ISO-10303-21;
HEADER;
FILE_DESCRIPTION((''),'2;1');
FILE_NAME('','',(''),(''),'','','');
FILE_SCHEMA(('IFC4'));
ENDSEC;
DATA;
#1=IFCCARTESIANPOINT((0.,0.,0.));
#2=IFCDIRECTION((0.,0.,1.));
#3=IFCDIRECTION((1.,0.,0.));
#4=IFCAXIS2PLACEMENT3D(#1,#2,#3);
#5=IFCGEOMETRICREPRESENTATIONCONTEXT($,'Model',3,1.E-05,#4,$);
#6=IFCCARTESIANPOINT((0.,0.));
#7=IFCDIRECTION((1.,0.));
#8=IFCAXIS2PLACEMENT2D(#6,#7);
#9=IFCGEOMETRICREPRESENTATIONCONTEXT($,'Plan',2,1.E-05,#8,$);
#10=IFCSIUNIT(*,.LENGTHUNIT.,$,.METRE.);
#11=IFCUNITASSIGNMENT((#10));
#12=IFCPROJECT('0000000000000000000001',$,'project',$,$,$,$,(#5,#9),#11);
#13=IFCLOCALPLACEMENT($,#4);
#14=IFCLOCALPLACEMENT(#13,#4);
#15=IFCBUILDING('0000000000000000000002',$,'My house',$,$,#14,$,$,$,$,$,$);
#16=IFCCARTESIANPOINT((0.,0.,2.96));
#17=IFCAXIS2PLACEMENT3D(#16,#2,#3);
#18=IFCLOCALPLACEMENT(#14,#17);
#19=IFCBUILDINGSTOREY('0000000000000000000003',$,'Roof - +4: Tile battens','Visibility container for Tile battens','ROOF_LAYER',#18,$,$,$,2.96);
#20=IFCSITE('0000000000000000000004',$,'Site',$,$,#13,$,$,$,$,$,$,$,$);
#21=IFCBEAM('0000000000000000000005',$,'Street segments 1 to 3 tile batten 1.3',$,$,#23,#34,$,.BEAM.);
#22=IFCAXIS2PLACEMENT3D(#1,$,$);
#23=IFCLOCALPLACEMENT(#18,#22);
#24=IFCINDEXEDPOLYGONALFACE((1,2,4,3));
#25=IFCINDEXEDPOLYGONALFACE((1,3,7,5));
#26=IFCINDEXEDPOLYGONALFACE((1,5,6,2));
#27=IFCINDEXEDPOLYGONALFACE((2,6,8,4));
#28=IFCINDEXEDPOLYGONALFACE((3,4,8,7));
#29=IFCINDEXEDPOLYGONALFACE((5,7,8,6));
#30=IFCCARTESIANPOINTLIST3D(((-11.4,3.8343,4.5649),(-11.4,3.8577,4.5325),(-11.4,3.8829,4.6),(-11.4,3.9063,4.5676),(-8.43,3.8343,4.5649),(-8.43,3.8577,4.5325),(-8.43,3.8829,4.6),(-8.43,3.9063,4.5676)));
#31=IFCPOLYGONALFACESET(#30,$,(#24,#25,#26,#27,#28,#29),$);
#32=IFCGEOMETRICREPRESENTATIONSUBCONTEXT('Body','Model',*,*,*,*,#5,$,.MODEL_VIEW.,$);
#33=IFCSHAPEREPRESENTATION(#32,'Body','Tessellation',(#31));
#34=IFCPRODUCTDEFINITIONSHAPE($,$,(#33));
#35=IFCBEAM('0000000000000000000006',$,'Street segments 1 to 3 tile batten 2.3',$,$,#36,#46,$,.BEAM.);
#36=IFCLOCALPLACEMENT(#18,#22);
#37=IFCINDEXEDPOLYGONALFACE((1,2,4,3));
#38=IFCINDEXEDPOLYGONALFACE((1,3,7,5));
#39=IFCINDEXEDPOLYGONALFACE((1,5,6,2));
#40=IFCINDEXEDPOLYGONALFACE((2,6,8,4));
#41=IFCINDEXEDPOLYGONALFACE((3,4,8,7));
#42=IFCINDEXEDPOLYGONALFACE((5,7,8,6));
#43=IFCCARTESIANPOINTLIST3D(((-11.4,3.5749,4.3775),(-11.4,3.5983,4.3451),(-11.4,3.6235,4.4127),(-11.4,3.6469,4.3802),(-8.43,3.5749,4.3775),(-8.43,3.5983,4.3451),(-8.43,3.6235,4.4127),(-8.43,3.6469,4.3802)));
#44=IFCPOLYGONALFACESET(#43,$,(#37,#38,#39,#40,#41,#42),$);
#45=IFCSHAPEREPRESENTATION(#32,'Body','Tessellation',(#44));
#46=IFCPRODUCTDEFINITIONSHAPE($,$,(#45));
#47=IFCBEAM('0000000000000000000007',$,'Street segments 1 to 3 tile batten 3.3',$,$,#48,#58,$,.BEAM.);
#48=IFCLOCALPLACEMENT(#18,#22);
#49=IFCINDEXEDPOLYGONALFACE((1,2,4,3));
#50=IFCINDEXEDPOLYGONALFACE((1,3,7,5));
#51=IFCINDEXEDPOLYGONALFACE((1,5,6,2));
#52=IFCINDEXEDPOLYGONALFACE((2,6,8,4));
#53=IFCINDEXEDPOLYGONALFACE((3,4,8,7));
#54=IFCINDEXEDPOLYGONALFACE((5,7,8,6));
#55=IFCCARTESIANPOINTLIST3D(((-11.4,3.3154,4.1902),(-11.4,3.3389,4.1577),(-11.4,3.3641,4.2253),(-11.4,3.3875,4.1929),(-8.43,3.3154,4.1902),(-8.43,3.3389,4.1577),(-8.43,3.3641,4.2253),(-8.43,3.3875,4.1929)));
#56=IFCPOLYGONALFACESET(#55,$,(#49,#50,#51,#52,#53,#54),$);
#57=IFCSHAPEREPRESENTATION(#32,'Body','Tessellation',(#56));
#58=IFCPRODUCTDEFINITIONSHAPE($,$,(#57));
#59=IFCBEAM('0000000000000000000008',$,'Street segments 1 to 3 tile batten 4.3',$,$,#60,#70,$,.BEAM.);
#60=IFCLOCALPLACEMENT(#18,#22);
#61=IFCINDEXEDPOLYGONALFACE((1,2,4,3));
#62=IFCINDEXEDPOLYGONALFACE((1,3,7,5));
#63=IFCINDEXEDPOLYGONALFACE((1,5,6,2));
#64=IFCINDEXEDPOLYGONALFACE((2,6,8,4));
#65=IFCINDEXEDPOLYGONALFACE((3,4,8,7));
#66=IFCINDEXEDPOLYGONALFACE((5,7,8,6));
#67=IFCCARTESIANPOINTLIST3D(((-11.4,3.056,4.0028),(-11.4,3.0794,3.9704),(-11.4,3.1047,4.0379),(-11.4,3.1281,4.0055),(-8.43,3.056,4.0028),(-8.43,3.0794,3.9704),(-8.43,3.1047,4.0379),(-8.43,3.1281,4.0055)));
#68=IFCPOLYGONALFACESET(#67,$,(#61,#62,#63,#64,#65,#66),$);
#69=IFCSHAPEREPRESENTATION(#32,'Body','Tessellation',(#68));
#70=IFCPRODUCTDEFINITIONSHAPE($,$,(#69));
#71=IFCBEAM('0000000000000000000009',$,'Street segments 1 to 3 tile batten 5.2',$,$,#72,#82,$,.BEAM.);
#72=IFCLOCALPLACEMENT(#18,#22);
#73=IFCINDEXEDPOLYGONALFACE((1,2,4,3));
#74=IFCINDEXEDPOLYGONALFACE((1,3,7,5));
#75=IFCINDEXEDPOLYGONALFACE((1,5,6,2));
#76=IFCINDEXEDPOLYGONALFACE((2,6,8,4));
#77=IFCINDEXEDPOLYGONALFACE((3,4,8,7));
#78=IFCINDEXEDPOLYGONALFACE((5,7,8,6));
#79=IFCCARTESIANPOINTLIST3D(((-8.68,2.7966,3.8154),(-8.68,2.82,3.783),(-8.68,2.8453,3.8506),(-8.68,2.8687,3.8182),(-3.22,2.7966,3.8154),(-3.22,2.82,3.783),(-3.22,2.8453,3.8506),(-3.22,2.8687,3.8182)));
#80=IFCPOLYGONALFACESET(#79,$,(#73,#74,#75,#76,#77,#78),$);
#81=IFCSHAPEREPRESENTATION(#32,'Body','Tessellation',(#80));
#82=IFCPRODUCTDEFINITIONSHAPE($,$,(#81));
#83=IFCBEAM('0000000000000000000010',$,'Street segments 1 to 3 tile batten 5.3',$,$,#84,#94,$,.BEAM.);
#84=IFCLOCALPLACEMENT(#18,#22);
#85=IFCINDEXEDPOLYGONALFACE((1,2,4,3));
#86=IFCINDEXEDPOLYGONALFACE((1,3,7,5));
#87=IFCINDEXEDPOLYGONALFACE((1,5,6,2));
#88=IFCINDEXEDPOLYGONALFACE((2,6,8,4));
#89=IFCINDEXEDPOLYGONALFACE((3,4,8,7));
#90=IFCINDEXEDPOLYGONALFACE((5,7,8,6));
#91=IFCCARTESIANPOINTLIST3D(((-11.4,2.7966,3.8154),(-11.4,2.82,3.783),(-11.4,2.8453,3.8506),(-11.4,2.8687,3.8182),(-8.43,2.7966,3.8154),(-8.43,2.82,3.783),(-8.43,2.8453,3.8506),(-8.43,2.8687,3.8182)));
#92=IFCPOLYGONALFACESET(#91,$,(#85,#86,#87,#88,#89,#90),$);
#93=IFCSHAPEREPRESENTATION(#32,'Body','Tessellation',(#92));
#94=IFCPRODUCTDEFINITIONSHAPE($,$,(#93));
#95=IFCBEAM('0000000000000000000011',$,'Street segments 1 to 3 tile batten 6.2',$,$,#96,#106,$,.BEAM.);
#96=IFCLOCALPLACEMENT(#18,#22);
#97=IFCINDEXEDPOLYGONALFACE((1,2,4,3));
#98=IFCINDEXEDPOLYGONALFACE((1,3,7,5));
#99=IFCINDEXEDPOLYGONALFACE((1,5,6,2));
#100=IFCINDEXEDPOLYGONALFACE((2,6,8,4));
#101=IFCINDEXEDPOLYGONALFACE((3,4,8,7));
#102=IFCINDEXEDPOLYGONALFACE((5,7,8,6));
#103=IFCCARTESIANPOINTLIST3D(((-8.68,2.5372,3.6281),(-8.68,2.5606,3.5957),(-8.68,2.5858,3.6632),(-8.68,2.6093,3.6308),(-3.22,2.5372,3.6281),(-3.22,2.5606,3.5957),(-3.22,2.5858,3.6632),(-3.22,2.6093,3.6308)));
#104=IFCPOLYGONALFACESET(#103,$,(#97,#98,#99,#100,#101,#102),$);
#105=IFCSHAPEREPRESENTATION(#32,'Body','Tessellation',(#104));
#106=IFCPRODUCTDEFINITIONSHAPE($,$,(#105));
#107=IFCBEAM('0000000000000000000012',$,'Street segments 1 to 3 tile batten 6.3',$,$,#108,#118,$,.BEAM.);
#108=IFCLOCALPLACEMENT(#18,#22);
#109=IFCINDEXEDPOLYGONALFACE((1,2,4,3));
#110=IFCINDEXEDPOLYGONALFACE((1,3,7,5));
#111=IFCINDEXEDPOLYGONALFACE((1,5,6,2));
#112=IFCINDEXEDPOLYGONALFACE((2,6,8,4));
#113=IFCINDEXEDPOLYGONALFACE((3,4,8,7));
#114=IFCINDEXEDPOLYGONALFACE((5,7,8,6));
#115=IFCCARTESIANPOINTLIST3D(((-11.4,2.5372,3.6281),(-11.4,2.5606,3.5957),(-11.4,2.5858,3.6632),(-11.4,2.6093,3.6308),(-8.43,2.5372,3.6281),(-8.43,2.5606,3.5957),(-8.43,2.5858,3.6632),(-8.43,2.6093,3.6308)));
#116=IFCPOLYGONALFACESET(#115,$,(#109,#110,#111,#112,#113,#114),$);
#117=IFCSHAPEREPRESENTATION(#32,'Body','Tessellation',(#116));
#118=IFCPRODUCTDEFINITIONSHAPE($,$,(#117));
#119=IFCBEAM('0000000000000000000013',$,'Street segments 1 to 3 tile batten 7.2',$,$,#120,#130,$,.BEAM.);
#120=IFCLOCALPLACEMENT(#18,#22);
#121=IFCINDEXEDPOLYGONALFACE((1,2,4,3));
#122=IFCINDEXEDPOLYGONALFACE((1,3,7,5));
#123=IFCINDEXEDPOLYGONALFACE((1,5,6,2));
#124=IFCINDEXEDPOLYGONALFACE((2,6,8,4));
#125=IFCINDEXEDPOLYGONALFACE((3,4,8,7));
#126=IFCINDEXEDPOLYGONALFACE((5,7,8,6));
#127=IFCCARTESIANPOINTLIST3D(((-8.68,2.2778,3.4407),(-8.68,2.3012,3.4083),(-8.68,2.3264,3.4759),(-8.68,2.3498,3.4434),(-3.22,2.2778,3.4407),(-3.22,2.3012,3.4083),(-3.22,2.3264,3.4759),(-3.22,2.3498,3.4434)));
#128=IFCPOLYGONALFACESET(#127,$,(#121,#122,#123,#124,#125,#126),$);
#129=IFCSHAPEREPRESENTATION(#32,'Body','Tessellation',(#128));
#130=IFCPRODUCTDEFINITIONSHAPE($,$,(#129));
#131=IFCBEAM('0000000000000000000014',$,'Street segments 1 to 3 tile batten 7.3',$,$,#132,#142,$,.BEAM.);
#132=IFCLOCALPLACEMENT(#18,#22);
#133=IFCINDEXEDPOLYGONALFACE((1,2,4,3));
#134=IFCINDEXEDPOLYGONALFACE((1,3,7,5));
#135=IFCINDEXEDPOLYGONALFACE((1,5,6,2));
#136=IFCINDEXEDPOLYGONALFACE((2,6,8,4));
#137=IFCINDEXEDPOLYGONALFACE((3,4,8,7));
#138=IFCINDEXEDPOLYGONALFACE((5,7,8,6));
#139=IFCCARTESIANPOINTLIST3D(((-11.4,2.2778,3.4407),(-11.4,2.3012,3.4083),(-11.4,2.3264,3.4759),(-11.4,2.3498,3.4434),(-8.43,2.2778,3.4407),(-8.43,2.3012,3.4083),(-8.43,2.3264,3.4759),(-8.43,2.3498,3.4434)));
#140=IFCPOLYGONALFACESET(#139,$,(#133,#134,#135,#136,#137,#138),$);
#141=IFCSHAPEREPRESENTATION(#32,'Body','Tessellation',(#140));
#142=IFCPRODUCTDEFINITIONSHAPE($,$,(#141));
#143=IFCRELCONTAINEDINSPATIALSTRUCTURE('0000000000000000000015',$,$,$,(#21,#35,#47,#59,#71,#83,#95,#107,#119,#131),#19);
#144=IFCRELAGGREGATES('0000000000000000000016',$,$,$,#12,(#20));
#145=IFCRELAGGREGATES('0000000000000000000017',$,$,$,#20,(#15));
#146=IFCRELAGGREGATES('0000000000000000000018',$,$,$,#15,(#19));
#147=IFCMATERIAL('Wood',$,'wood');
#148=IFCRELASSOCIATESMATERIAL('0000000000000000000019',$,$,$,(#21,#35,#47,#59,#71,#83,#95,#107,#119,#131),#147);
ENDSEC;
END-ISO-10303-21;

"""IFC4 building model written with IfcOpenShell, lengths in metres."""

from ifc_helpers import new_model, si_unit, frame, origin_with_axes, origin_2d_with_axis, place, context, subcontext, project, spatial, rectangle, extrude, clip, halfspace, source, transform, mapped, material, element, save


model = new_model("IFC4")

# Units and contexts
model_context = context("Model", 3, precision=1e-05, world=origin_with_axes())
plan_context = context("Plan", 2, precision=1e-05, world=origin_2d_with_axis())
body_context = subcontext(model_context, "Body", "Model", "MODEL_VIEW")
ifc_project = project(units=[si_unit("LENGTHUNIT", "METRE")], contexts=[model_context, plan_context])

# Site, building, storey
site_placement = place(None, origin_with_axes())
site = spatial("IfcSite", under=ifc_project, at=site_placement, Name="Site")
building_placement = place(site_placement, origin_with_axes())
building = spatial("IfcBuilding", under=site, at=building_placement, Name="My house")
storey_placement = place(building_placement, frame((0.0, 0.0, 2.96), z_axis=(0.0, 0.0, 1.0), x_axis=(1.0, 0.0, 0.0)))
storey = spatial("IfcBuildingStorey", under=building, at=storey_placement, Name="Roof - +4: Tile battens", Description="Visibility container for Tile battens", ObjectType="ROOF_LAYER", Elevation=2.96)

# Beams
ifc_material = material(Name="Wood", Category="wood")
shared_shape_1 = source(origin_with_axes(), body_context, "Body", "Clipping", [
    clip(clip(extrude(rectangle(XDim=0.06, YDim=0.04), frame((0.0, 0.0, 0.0), z_axis=(1.0, 0.0, 0.0), x_axis=(0.0, 1.0, 0.0)), (0.0, 0.0, 1.0), 2.97), halfspace(frame((-8.43, -4.3016, -6.1772), z_axis=(0.0, 0.810664, -0.585512), x_axis=(1.0, 0.0, 0.0)), False)), halfspace(frame((-8.43, -8.1522, -3.396), z_axis=(0.0, -0.810664, 0.585512), x_axis=(-1.0, 0.0, 0.0)), False)),
])
beam_1_placement = place(storey_placement, frame((-8.43, 3.8703, 4.5663), z_axis=(0.0, -0.585512, 0.810664), x_axis=(1.0, 0.0, 0.0)))
element("IfcBeam", 1, at=beam_1_placement, inside=storey, material=ifc_material, Name="Street segments 1 to 3 tile batten 1.3", PredefinedType="BEAM", context=body_context, shape_type="MappedRepresentation", body=[
    mapped(shared_shape_1, transform((0.0, 0.0, 0.0), x_axis=(-1.0, 0.0, 0.0), y_axis=(0.0, 1.0, 0.0), z_axis=(0.0, 0.0, 1.0), scale=1.0)),
])
shared_shape_2 = source(origin_with_axes(), body_context, "Body", "Clipping", [
    clip(clip(extrude(rectangle(XDim=0.06, YDim=0.04), frame((0.0, 0.0, 0.0), z_axis=(1.0, 0.0, 0.0), x_axis=(0.0, 1.0, 0.0)), (0.0, 0.0, 1.0), 2.97), halfspace(frame((-8.43, -3.9816, -6.1772), z_axis=(0.0, 0.810664, -0.585512), x_axis=(1.0, 0.0, 0.0)), False)), halfspace(frame((-8.43, -7.8322, -3.396), z_axis=(0.0, -0.810664, 0.585512), x_axis=(-1.0, 0.0, 0.0)), False)),
])
beam_2_placement = place(storey_placement, frame((-8.43, 3.6109, 4.3789), z_axis=(0.0, -0.585512, 0.810664), x_axis=(1.0, 0.0, 0.0)))
element("IfcBeam", 2, at=beam_2_placement, inside=storey, material=ifc_material, Name="Street segments 1 to 3 tile batten 2.3", PredefinedType="BEAM", context=body_context, shape_type="MappedRepresentation", body=[
    mapped(shared_shape_2, transform((0.0, 0.0, 0.0), x_axis=(-1.0, 0.0, 0.0), y_axis=(0.0, 1.0, 0.0), z_axis=(0.0, 0.0, 1.0), scale=1.0)),
])
shared_shape_3 = source(origin_with_axes(), body_context, "Body", "Clipping", [
    clip(clip(extrude(rectangle(XDim=0.06, YDim=0.04), frame((0.0, 0.0, 0.0), z_axis=(1.0, 0.0, 0.0), x_axis=(0.0, 1.0, 0.0)), (0.0, 0.0, 1.0), 2.97), halfspace(frame((-8.43, -3.6616, -6.1772), z_axis=(0.0, 0.810664, -0.585512), x_axis=(1.0, 0.0, 0.0)), False)), halfspace(frame((-8.43, -7.5122, -3.396), z_axis=(0.0, -0.810664, 0.585512), x_axis=(-1.0, 0.0, 0.0)), False)),
])
beam_3_placement = place(storey_placement, frame((-8.43, 3.3515, 4.1915), z_axis=(0.0, -0.585512, 0.810664), x_axis=(1.0, 0.0, 0.0)))
element("IfcBeam", 3, at=beam_3_placement, inside=storey, material=ifc_material, Name="Street segments 1 to 3 tile batten 3.3", PredefinedType="BEAM", context=body_context, shape_type="MappedRepresentation", body=[
    mapped(shared_shape_3, transform((0.0, 0.0, 0.0), x_axis=(-1.0, 0.0, 0.0), y_axis=(0.0, 1.0, 0.0), z_axis=(0.0, 0.0, 1.0), scale=1.0)),
])
shared_shape_4 = source(origin_with_axes(), body_context, "Body", "Clipping", [
    clip(clip(extrude(rectangle(XDim=0.06, YDim=0.04), frame((0.0, 0.0, 0.0), z_axis=(1.0, 0.0, 0.0), x_axis=(0.0, 1.0, 0.0)), (0.0, 0.0, 1.0), 2.97), halfspace(frame((-8.43, -3.3416, -6.1772), z_axis=(0.0, 0.810664, -0.585512), x_axis=(1.0, 0.0, 0.0)), False)), halfspace(frame((-8.43, -7.1922, -3.396), z_axis=(0.0, -0.810664, 0.585512), x_axis=(-1.0, 0.0, 0.0)), False)),
])
beam_4_placement = place(storey_placement, frame((-8.43, 3.0921, 4.0042), z_axis=(0.0, -0.585512, 0.810664), x_axis=(1.0, 0.0, 0.0)))
element("IfcBeam", 4, at=beam_4_placement, inside=storey, material=ifc_material, Name="Street segments 1 to 3 tile batten 4.3", PredefinedType="BEAM", context=body_context, shape_type="MappedRepresentation", body=[
    mapped(shared_shape_4, transform((0.0, 0.0, 0.0), x_axis=(-1.0, 0.0, 0.0), y_axis=(0.0, 1.0, 0.0), z_axis=(0.0, 0.0, 1.0), scale=1.0)),
])
shared_shape_5 = source(origin_with_axes(), body_context, "Body", "Clipping", [
    clip(clip(extrude(rectangle(XDim=0.06, YDim=0.04), frame((0.0, 0.0, 0.0), z_axis=(1.0, 0.0, 0.0), x_axis=(0.0, 1.0, 0.0)), (0.0, 0.0, 1.0), 5.46), halfspace(frame((-3.22, -3.0216, -6.1772), z_axis=(0.0, 0.810664, -0.585512), x_axis=(1.0, 0.0, 0.0)), False)), halfspace(frame((-3.22, -6.8722, -3.396), z_axis=(0.0, -0.810664, 0.585512), x_axis=(-1.0, 0.0, 0.0)), False)),
])
beam_5_placement = place(storey_placement, frame((-3.22, 2.8326, 3.8168), z_axis=(0.0, -0.585512, 0.810664), x_axis=(1.0, 0.0, 0.0)))
element("IfcBeam", 5, at=beam_5_placement, inside=storey, material=ifc_material, Name="Street segments 1 to 3 tile batten 5.2", PredefinedType="BEAM", context=body_context, shape_type="MappedRepresentation", body=[
    mapped(shared_shape_5, transform((0.0, 0.0, 0.0), x_axis=(-1.0, 0.0, 0.0), y_axis=(0.0, 1.0, 0.0), z_axis=(0.0, 0.0, 1.0), scale=1.0)),
])
shared_shape_6 = source(origin_with_axes(), body_context, "Body", "Clipping", [
    clip(clip(extrude(rectangle(XDim=0.06, YDim=0.04), frame((0.0, 0.0, 0.0), z_axis=(1.0, 0.0, 0.0), x_axis=(0.0, 1.0, 0.0)), (0.0, 0.0, 1.0), 2.97), halfspace(frame((-8.43, -3.0216, -6.1772), z_axis=(0.0, 0.810664, -0.585512), x_axis=(1.0, 0.0, 0.0)), False)), halfspace(frame((-8.43, -6.8722, -3.396), z_axis=(0.0, -0.810664, 0.585512), x_axis=(-1.0, 0.0, 0.0)), False)),
])
beam_6_placement = place(storey_placement, frame((-8.43, 2.8326, 3.8168), z_axis=(0.0, -0.585512, 0.810664), x_axis=(1.0, 0.0, 0.0)))
element("IfcBeam", 6, at=beam_6_placement, inside=storey, material=ifc_material, Name="Street segments 1 to 3 tile batten 5.3", PredefinedType="BEAM", context=body_context, shape_type="MappedRepresentation", body=[
    mapped(shared_shape_6, transform((0.0, 0.0, 0.0), x_axis=(-1.0, 0.0, 0.0), y_axis=(0.0, 1.0, 0.0), z_axis=(0.0, 0.0, 1.0), scale=1.0)),
])
shared_shape_7 = source(origin_with_axes(), body_context, "Body", "Clipping", [
    clip(clip(extrude(rectangle(XDim=0.06, YDim=0.04), frame((0.0, 0.0, 0.0), z_axis=(1.0, 0.0, 0.0), x_axis=(0.0, 1.0, 0.0)), (0.0, 0.0, 1.0), 5.46), halfspace(frame((-3.22, -2.7016, -6.1772), z_axis=(0.0, 0.810664, -0.585512), x_axis=(1.0, 0.0, 0.0)), False)), halfspace(frame((-3.22, -6.5522, -3.396), z_axis=(0.0, -0.810664, 0.585512), x_axis=(-1.0, 0.0, 0.0)), False)),
])
beam_7_placement = place(storey_placement, frame((-3.22, 2.5732, 3.6294), z_axis=(0.0, -0.585512, 0.810664), x_axis=(1.0, 0.0, 0.0)))
element("IfcBeam", 7, at=beam_7_placement, inside=storey, material=ifc_material, Name="Street segments 1 to 3 tile batten 6.2", PredefinedType="BEAM", context=body_context, shape_type="MappedRepresentation", body=[
    mapped(shared_shape_7, transform((0.0, 0.0, 0.0), x_axis=(-1.0, 0.0, 0.0), y_axis=(0.0, 1.0, 0.0), z_axis=(0.0, 0.0, 1.0), scale=1.0)),
])
shared_shape_8 = source(origin_with_axes(), body_context, "Body", "Clipping", [
    clip(clip(extrude(rectangle(XDim=0.06, YDim=0.04), frame((0.0, 0.0, 0.0), z_axis=(1.0, 0.0, 0.0), x_axis=(0.0, 1.0, 0.0)), (0.0, 0.0, 1.0), 2.97), halfspace(frame((-8.43, -2.7016, -6.1772), z_axis=(0.0, 0.810664, -0.585512), x_axis=(1.0, 0.0, 0.0)), False)), halfspace(frame((-8.43, -6.5522, -3.396), z_axis=(0.0, -0.810664, 0.585512), x_axis=(-1.0, 0.0, 0.0)), False)),
])
beam_8_placement = place(storey_placement, frame((-8.43, 2.5732, 3.6294), z_axis=(0.0, -0.585512, 0.810664), x_axis=(1.0, 0.0, 0.0)))
element("IfcBeam", 8, at=beam_8_placement, inside=storey, material=ifc_material, Name="Street segments 1 to 3 tile batten 6.3", PredefinedType="BEAM", context=body_context, shape_type="MappedRepresentation", body=[
    mapped(shared_shape_8, transform((0.0, 0.0, 0.0), x_axis=(-1.0, 0.0, 0.0), y_axis=(0.0, 1.0, 0.0), z_axis=(0.0, 0.0, 1.0), scale=1.0)),
])
shared_shape_9 = source(origin_with_axes(), body_context, "Body", "Clipping", [
    clip(clip(extrude(rectangle(XDim=0.06, YDim=0.04), frame((0.0, 0.0, 0.0), z_axis=(1.0, 0.0, 0.0), x_axis=(0.0, 1.0, 0.0)), (0.0, 0.0, 1.0), 5.46), halfspace(frame((-3.22, -2.3816, -6.1772), z_axis=(0.0, 0.810664, -0.585512), x_axis=(1.0, 0.0, 0.0)), False)), halfspace(frame((-3.22, -6.2322, -3.396), z_axis=(0.0, -0.810664, 0.585512), x_axis=(-1.0, 0.0, 0.0)), False)),
])
beam_9_placement = place(storey_placement, frame((-3.22, 2.3138, 3.4421), z_axis=(0.0, -0.585512, 0.810664), x_axis=(1.0, 0.0, 0.0)))
element("IfcBeam", 9, at=beam_9_placement, inside=storey, material=ifc_material, Name="Street segments 1 to 3 tile batten 7.2", PredefinedType="BEAM", context=body_context, shape_type="MappedRepresentation", body=[
    mapped(shared_shape_9, transform((0.0, 0.0, 0.0), x_axis=(-1.0, 0.0, 0.0), y_axis=(0.0, 1.0, 0.0), z_axis=(0.0, 0.0, 1.0), scale=1.0)),
])
shared_shape_10 = source(origin_with_axes(), body_context, "Body", "Clipping", [
    clip(clip(extrude(rectangle(XDim=0.06, YDim=0.04), frame((0.0, 0.0, 0.0), z_axis=(1.0, 0.0, 0.0), x_axis=(0.0, 1.0, 0.0)), (0.0, 0.0, 1.0), 2.97), halfspace(frame((-8.43, -2.3816, -6.1772), z_axis=(0.0, 0.810664, -0.585512), x_axis=(1.0, 0.0, 0.0)), False)), halfspace(frame((-8.43, -6.2322, -3.396), z_axis=(0.0, -0.810664, 0.585512), x_axis=(-1.0, 0.0, 0.0)), False)),
])
beam_10_placement = place(storey_placement, frame((-8.43, 2.3138, 3.4421), z_axis=(0.0, -0.585512, 0.810664), x_axis=(1.0, 0.0, 0.0)))
element("IfcBeam", 10, at=beam_10_placement, inside=storey, material=ifc_material, Name="Street segments 1 to 3 tile batten 7.3", PredefinedType="BEAM", context=body_context, shape_type="MappedRepresentation", body=[
    mapped(shared_shape_10, transform((0.0, 0.0, 0.0), x_axis=(-1.0, 0.0, 0.0), y_axis=(0.0, 1.0, 0.0), z_axis=(0.0, 0.0, 1.0), scale=1.0)),
])

save(model, "model.ifc")
